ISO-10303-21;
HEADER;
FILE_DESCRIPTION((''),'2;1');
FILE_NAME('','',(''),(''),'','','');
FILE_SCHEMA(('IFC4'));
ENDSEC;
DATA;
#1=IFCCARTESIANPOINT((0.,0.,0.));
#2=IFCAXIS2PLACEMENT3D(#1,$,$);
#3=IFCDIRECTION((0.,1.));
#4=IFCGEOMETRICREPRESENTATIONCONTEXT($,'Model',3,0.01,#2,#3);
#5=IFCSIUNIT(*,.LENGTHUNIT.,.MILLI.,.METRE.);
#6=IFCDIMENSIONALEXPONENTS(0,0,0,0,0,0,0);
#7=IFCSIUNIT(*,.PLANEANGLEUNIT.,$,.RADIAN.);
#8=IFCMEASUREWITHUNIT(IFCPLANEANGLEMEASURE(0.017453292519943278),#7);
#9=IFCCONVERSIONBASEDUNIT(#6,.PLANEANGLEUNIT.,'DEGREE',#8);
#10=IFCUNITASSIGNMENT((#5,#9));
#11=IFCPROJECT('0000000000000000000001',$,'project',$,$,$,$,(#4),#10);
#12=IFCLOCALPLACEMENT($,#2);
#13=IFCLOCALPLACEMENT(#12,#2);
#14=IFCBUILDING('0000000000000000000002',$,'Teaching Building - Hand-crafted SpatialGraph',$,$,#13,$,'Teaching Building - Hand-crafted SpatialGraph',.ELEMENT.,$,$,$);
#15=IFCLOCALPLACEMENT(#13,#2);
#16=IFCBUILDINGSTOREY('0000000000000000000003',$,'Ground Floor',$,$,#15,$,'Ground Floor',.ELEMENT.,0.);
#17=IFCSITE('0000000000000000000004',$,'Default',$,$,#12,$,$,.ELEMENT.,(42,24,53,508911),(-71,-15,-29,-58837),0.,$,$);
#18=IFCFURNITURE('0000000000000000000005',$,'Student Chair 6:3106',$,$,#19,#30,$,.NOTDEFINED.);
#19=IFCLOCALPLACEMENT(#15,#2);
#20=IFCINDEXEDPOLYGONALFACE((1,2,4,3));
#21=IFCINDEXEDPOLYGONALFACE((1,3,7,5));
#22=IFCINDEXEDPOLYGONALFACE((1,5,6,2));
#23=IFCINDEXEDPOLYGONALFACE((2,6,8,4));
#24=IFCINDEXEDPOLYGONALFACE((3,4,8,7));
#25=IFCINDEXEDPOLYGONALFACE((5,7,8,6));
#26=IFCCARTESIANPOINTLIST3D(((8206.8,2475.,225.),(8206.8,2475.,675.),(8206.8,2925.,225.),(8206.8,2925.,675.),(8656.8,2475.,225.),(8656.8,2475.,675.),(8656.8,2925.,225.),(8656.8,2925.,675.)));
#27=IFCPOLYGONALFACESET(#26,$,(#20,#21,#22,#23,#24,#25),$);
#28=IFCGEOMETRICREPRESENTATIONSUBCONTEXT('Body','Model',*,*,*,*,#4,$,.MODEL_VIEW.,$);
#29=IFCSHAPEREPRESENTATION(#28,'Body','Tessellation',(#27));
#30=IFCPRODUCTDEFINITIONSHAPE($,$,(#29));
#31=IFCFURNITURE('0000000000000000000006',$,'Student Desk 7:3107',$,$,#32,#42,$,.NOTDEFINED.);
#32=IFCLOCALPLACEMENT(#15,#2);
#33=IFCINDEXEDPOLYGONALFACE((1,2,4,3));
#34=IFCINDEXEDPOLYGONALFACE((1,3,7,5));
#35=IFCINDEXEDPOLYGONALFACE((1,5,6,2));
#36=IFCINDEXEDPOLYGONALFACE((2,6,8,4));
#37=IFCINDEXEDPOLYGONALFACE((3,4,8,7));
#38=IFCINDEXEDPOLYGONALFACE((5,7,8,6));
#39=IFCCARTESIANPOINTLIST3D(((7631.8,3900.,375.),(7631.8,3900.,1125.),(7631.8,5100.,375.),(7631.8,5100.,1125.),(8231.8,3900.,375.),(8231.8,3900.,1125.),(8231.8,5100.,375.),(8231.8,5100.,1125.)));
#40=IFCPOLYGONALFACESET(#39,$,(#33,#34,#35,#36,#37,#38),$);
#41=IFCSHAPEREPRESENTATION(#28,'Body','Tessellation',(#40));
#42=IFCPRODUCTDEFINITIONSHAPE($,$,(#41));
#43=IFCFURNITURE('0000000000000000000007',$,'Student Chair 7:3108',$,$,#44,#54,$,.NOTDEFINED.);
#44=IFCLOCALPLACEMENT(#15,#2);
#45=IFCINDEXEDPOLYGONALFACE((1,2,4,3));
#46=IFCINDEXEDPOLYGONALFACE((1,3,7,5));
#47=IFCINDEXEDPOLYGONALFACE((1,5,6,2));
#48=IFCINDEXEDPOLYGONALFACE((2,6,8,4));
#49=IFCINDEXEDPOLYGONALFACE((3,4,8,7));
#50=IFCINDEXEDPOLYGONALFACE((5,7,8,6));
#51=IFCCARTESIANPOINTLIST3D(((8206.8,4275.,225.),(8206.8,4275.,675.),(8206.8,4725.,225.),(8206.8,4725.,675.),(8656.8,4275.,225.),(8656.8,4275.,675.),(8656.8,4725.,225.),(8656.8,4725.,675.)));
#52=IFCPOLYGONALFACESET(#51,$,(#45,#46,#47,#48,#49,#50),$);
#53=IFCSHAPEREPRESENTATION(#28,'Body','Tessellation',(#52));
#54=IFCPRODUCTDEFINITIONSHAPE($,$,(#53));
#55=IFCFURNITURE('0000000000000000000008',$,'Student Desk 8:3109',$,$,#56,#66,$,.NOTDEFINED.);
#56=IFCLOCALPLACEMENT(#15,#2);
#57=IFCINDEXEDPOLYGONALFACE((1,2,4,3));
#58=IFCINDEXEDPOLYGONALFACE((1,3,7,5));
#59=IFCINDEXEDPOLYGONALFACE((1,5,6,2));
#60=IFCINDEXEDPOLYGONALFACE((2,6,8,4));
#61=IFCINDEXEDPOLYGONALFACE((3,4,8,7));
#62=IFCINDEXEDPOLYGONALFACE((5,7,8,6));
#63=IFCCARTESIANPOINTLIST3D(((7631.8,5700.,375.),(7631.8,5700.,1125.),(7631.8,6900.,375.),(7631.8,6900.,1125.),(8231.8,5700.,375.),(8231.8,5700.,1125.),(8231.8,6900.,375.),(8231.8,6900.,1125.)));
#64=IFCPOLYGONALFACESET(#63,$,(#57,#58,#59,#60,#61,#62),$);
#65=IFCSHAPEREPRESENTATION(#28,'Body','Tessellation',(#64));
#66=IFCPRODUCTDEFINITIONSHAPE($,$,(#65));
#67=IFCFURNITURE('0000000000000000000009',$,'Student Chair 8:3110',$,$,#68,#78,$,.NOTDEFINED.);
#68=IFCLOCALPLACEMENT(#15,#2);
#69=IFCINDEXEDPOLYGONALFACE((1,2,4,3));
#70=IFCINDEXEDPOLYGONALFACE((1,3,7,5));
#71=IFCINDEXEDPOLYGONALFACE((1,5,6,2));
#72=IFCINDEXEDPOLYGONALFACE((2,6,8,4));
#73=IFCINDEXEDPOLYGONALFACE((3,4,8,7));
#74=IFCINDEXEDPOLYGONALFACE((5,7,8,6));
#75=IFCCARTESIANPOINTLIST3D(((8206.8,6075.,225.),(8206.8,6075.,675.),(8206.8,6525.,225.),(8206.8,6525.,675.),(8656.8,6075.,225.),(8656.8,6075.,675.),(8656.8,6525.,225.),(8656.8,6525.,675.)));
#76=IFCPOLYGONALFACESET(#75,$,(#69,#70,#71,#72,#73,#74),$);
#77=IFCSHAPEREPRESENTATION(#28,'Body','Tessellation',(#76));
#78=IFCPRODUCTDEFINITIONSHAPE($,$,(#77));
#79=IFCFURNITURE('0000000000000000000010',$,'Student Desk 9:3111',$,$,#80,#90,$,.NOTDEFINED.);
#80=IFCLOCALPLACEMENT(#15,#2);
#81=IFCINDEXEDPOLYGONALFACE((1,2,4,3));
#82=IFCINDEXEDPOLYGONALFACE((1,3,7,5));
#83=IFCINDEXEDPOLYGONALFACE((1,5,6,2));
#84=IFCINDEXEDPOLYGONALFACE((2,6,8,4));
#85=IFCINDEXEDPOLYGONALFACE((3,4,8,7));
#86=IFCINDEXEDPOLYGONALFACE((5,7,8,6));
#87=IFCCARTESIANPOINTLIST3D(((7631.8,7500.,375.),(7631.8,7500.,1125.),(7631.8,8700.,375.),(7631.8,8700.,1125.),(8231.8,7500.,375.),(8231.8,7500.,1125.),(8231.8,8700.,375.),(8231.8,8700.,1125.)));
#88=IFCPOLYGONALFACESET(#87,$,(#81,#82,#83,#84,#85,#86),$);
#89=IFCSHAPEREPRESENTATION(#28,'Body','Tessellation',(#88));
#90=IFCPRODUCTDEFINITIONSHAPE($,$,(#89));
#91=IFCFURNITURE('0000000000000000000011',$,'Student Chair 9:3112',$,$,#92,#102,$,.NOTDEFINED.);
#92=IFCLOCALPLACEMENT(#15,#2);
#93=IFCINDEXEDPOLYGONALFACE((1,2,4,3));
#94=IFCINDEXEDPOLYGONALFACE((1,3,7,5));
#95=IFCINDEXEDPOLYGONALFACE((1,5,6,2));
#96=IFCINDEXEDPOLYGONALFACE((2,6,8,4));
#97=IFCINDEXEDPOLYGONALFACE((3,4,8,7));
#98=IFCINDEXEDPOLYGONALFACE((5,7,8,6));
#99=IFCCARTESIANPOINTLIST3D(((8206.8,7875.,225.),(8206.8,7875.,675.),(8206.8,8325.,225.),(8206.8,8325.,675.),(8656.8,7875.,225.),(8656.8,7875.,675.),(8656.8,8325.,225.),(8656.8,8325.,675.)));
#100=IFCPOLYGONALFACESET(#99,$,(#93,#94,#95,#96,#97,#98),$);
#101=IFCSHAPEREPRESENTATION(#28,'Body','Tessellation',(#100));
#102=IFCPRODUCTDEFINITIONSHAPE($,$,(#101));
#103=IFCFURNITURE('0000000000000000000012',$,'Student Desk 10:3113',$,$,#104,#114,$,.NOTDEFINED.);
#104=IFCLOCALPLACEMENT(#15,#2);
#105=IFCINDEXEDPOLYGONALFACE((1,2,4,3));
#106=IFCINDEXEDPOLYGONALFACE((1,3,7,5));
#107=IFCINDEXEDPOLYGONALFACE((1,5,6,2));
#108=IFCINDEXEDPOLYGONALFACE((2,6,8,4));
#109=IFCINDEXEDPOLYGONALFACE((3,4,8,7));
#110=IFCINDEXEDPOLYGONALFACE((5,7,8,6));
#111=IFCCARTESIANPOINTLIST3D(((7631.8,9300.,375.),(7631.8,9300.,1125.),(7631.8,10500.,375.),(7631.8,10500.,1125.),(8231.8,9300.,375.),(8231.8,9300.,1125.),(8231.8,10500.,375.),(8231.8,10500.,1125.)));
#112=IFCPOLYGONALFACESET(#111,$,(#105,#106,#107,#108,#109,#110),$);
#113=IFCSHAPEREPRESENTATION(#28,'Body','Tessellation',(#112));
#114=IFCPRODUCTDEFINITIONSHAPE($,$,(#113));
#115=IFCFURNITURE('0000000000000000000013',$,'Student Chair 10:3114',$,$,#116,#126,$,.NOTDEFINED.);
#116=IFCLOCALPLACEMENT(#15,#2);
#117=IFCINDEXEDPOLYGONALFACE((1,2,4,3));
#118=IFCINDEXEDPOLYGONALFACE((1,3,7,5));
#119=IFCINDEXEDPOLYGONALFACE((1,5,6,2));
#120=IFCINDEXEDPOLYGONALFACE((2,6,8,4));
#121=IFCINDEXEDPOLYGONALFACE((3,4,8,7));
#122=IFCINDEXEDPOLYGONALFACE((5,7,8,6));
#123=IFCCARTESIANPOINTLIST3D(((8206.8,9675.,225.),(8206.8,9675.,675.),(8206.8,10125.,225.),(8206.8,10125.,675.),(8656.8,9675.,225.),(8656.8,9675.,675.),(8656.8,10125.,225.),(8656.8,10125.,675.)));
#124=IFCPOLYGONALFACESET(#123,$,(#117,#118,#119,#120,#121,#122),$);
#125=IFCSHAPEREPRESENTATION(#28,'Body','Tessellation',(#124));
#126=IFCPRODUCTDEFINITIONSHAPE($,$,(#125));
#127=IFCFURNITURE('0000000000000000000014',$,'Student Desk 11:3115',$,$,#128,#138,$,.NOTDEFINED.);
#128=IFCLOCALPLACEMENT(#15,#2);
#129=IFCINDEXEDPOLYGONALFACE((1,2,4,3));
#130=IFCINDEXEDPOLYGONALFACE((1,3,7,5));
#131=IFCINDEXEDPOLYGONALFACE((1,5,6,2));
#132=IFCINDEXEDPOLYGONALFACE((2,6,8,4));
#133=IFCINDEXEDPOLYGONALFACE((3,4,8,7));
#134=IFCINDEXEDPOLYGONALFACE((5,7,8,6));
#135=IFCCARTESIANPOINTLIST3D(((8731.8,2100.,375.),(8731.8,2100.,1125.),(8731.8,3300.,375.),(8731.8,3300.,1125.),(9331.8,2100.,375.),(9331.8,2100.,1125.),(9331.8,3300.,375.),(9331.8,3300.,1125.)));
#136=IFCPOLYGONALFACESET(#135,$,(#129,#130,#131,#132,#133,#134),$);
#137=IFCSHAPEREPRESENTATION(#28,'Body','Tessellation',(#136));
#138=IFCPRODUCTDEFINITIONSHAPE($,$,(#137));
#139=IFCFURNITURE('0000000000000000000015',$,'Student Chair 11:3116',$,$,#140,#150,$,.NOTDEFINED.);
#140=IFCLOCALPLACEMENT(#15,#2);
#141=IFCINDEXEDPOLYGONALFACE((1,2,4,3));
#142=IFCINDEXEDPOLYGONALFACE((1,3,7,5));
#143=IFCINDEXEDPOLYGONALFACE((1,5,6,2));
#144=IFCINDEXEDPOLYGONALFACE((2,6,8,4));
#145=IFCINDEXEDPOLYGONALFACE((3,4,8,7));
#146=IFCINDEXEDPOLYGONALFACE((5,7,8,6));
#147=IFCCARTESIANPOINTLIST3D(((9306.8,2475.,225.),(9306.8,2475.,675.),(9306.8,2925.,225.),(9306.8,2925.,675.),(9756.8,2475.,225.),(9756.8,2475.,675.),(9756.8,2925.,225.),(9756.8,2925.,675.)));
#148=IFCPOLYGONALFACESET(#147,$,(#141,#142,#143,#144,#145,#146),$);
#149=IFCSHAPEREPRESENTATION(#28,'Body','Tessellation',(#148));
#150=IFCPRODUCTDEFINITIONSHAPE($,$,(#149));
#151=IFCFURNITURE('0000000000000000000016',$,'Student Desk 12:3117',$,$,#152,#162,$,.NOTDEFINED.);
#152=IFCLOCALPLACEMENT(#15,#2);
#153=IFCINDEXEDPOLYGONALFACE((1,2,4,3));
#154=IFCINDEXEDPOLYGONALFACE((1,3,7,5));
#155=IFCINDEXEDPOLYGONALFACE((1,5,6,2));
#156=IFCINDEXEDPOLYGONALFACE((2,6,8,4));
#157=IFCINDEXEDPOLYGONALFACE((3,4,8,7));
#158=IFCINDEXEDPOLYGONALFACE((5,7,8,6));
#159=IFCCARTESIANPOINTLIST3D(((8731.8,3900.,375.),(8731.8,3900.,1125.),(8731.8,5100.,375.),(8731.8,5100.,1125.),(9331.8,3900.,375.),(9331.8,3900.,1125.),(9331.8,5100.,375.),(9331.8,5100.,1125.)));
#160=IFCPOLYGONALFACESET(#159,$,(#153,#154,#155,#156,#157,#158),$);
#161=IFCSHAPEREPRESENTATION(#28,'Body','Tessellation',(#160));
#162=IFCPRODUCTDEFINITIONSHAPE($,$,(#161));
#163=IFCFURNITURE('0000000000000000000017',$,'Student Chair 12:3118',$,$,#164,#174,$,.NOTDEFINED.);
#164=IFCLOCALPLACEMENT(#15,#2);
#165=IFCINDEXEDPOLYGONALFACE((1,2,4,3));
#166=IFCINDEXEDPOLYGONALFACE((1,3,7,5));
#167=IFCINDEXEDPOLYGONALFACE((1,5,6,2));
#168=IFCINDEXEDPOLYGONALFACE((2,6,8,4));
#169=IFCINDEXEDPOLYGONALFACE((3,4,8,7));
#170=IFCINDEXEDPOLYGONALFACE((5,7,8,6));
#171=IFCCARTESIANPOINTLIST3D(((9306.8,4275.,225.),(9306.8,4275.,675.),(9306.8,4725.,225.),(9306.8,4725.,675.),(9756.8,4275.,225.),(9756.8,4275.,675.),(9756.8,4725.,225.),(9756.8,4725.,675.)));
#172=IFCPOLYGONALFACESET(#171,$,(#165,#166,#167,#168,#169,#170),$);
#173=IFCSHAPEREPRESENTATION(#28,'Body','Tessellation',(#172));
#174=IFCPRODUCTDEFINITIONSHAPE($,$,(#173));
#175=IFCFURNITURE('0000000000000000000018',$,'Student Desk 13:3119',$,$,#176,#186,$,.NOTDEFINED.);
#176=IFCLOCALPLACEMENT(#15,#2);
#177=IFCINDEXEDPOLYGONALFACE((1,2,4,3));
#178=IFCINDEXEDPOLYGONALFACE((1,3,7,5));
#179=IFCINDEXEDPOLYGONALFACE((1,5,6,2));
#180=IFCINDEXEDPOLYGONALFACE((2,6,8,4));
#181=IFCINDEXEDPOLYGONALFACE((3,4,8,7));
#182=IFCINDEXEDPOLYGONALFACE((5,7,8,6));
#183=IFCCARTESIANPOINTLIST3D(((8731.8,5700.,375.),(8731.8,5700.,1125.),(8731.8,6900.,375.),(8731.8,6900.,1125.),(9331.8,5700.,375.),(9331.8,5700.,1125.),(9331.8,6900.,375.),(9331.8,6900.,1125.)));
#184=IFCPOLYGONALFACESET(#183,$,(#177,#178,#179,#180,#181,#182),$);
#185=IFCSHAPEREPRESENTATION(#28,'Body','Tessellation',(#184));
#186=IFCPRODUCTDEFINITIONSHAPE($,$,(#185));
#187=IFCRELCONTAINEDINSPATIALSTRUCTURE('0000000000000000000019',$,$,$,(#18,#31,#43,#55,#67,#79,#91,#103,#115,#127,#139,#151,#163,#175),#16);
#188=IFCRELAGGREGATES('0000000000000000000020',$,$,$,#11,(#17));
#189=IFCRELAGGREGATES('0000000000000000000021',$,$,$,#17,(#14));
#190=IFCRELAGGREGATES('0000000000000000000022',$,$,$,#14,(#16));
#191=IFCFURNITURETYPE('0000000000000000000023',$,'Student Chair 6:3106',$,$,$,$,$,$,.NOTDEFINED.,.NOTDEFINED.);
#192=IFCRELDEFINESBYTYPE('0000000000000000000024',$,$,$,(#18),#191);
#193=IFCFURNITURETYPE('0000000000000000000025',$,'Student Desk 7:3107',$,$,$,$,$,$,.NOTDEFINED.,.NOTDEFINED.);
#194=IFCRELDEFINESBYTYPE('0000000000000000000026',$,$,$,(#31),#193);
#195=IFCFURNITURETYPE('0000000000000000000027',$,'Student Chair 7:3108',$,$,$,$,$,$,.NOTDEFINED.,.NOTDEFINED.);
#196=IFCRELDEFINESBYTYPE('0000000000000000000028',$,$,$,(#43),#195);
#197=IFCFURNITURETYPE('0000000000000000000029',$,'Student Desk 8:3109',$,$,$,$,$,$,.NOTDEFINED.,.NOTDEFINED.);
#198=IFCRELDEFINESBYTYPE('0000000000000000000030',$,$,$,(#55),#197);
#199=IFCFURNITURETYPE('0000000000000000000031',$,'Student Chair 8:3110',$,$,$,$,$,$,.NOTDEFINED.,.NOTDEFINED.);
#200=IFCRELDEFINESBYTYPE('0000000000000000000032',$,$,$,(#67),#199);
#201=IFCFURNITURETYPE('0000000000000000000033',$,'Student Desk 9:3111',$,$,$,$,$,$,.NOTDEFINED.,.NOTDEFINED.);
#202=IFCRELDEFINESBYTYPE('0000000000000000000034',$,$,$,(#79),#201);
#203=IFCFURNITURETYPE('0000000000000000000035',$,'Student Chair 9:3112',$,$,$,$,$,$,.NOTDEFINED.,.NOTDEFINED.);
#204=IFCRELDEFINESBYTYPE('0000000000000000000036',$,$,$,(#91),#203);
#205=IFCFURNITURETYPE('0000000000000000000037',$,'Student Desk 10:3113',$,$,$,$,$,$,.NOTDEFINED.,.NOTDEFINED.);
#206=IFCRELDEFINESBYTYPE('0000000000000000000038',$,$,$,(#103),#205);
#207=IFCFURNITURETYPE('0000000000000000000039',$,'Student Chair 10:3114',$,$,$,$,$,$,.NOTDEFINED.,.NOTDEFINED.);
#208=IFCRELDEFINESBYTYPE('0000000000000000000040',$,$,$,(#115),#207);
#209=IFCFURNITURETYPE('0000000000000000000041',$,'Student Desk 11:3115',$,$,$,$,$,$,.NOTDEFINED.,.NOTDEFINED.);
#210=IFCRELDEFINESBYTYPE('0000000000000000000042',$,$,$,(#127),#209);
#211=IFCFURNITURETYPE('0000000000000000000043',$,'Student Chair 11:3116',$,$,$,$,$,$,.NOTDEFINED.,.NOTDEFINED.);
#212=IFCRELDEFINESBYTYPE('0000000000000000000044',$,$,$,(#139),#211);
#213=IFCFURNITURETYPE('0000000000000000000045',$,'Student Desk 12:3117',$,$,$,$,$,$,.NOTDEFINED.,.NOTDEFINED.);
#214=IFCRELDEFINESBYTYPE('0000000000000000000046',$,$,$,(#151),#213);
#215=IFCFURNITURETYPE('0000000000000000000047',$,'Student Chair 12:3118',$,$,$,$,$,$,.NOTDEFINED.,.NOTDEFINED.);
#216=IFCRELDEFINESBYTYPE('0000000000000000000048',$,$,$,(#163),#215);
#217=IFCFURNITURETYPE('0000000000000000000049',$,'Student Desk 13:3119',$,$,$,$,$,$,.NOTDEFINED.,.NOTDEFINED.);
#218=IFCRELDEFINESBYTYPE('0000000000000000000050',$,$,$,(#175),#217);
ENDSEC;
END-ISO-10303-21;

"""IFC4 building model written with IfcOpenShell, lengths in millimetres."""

from ifc_helpers import new_model, entity, si_unit, converted_unit, direction, frame, frame_2d, origin, origin_2d_with_axis, place, context, subcontext, project, spatial, rectangle, extrude, type_object, element, save


model = new_model("IFC4")

# Units and contexts
model_context = context("Model", 3, precision=0.01, world=origin(), true_north=direction((0.0, 1.0)))
body_context = subcontext(model_context, "Body", "Model", "MODEL_VIEW")
ifc_project = project(units=[si_unit("LENGTHUNIT", "METRE", prefix="MILLI"), converted_unit("PLANEANGLEUNIT", "DEGREE", entity("IfcPlaneAngleMeasure", 0.017453292519943278), si_unit("PLANEANGLEUNIT", "RADIAN"), dimensions=[0, 0, 0, 0, 0, 0, 0])], contexts=[model_context])

# Site, building, storey
site_placement = place(None, origin())
site = spatial("IfcSite", under=ifc_project, at=site_placement, Name="Default", CompositionType="ELEMENT", RefLatitude=(42, 24, 53, 508911), RefLongitude=(-71, -15, -29, -58837), RefElevation=0.0)
building_placement = place(site_placement, origin())
building = spatial("IfcBuilding", under=site, at=building_placement, Name="Teaching Building - Hand-crafted SpatialGraph", LongName="Teaching Building - Hand-crafted SpatialGraph", CompositionType="ELEMENT")
storey_placement = place(building_placement, origin())
storey = spatial("IfcBuildingStorey", under=building, at=storey_placement, Name="Ground Floor", LongName="Ground Floor", CompositionType="ELEMENT", Elevation=0.0)

# Furniture
furniture_type_1 = type_object("IfcFurnitureType", Name="Student Chair 6:3106", PredefinedType="NOTDEFINED")
furniture_1_placement = place(storey_placement, origin())
element("IfcFurniture", 1, at=furniture_1_placement, inside=storey, type_object=furniture_type_1, Name="Student Chair 6:3106", PredefinedType="NOTDEFINED", context=body_context, shape_type="SweptSolid", body=[
    extrude(rectangle(XDim=450.0, YDim=450.0, at=origin_2d_with_axis()), frame((8431.8, 2700.0, 225.0)), (0.0, 0.0, 1.0), 450.0),
])
furniture_type_2 = type_object("IfcFurnitureType", Name="Student Desk 7:3107", PredefinedType="NOTDEFINED")
furniture_2_placement = place(storey_placement, origin())
element("IfcFurniture", 2, at=furniture_2_placement, inside=storey, type_object=furniture_type_2, Name="Student Desk 7:3107", PredefinedType="NOTDEFINED", context=body_context, shape_type="SweptSolid", body=[
    extrude(rectangle(XDim=1200.0, YDim=600.0, at=frame_2d((0.0, 0.0), x_axis=(1.0, 0.0))), frame((7931.8, 4500.0, 375.0), z_axis=(0.0, 0.0, 1.0), x_axis=(0.0, 1.0, 0.0)), (0.0, 0.0, 1.0), 750.0),
])
furniture_type_3 = type_object("IfcFurnitureType", Name="Student Chair 7:3108", PredefinedType="NOTDEFINED")
furniture_3_placement = place(storey_placement, origin())
element("IfcFurniture", 3, at=furniture_3_placement, inside=storey, type_object=furniture_type_3, Name="Student Chair 7:3108", PredefinedType="NOTDEFINED", context=body_context, shape_type="SweptSolid", body=[
    extrude(rectangle(XDim=450.0, YDim=450.0, at=origin_2d_with_axis()), frame((8431.8, 4500.0, 225.0)), (0.0, 0.0, 1.0), 450.0),
])
furniture_type_4 = type_object("IfcFurnitureType", Name="Student Desk 8:3109", PredefinedType="NOTDEFINED")
furniture_4_placement = place(storey_placement, origin())
element("IfcFurniture", 4, at=furniture_4_placement, inside=storey, type_object=furniture_type_4, Name="Student Desk 8:3109", PredefinedType="NOTDEFINED", context=body_context, shape_type="SweptSolid", body=[
    extrude(rectangle(XDim=1200.0, YDim=600.0, at=origin_2d_with_axis()), frame((7931.8, 6300.0, 375.0), z_axis=(0.0, 0.0, 1.0), x_axis=(0.0, 1.0, 0.0)), (0.0, 0.0, 1.0), 750.0),
])
furniture_type_5 = type_object("IfcFurnitureType", Name="Student Chair 8:3110", PredefinedType="NOTDEFINED")
furniture_5_placement = place(storey_placement, origin())
element("IfcFurniture", 5, at=furniture_5_placement, inside=storey, type_object=furniture_type_5, Name="Student Chair 8:3110", PredefinedType="NOTDEFINED", context=body_context, shape_type="SweptSolid", body=[
    extrude(rectangle(XDim=450.0, YDim=450.0, at=origin_2d_with_axis()), frame((8431.8, 6300.0, 225.0)), (0.0, 0.0, 1.0), 450.0),
])
furniture_type_6 = type_object("IfcFurnitureType", Name="Student Desk 9:3111", PredefinedType="NOTDEFINED")
furniture_6_placement = place(storey_placement, origin())
element("IfcFurniture", 6, at=furniture_6_placement, inside=storey, type_object=furniture_type_6, Name="Student Desk 9:3111", PredefinedType="NOTDEFINED", context=body_context, shape_type="SweptSolid", body=[
    extrude(rectangle(XDim=1200.0, YDim=600.0, at=origin_2d_with_axis()), frame((7931.8, 8100.0, 375.0), z_axis=(0.0, 0.0, 1.0), x_axis=(0.0, 1.0, 0.0)), (0.0, 0.0, 1.0), 750.0),
])
furniture_type_7 = type_object("IfcFurnitureType", Name="Student Chair 9:3112", PredefinedType="NOTDEFINED")
furniture_7_placement = place(storey_placement, origin())
element("IfcFurniture", 7, at=furniture_7_placement, inside=storey, type_object=furniture_type_7, Name="Student Chair 9:3112", PredefinedType="NOTDEFINED", context=body_context, shape_type="SweptSolid", body=[
    extrude(rectangle(XDim=450.0, YDim=450.0, at=origin_2d_with_axis()), frame((8431.8, 8100.0, 225.0)), (0.0, 0.0, 1.0), 450.0),
])
furniture_type_8 = type_object("IfcFurnitureType", Name="Student Desk 10:3113", PredefinedType="NOTDEFINED")
furniture_8_placement = place(storey_placement, origin())
element("IfcFurniture", 8, at=furniture_8_placement, inside=storey, type_object=furniture_type_8, Name="Student Desk 10:3113", PredefinedType="NOTDEFINED", context=body_context, shape_type="SweptSolid", body=[
    extrude(rectangle(XDim=1200.0, YDim=600.0, at=origin_2d_with_axis()), frame((7931.8, 9900.0, 375.0), z_axis=(0.0, 0.0, 1.0), x_axis=(0.0, 1.0, 0.0)), (0.0, 0.0, 1.0), 750.0),
])
furniture_type_9 = type_object("IfcFurnitureType", Name="Student Chair 10:3114", PredefinedType="NOTDEFINED")
furniture_9_placement = place(storey_placement, origin())
element("IfcFurniture", 9, at=furniture_9_placement, inside=storey, type_object=furniture_type_9, Name="Student Chair 10:3114", PredefinedType="NOTDEFINED", context=body_context, shape_type="SweptSolid", body=[
    extrude(rectangle(XDim=450.0, YDim=450.0, at=frame_2d((0.0, 0.0), x_axis=(1.0, 0.0))), frame((8431.8, 9900.0, 225.0)), (0.0, 0.0, 1.0), 450.0),
])
furniture_type_10 = type_object("IfcFurnitureType", Name="Student Desk 11:3115", PredefinedType="NOTDEFINED")
furniture_10_placement = place(storey_placement, origin())
element("IfcFurniture", 10, at=furniture_10_placement, inside=storey, type_object=furniture_type_10, Name="Student Desk 11:3115", PredefinedType="NOTDEFINED", context=body_context, shape_type="SweptSolid", body=[
    extrude(rectangle(XDim=1200.0, YDim=600.0, at=origin_2d_with_axis()), frame((9031.8, 2700.0, 375.0), z_axis=(0.0, 0.0, 1.0), x_axis=(0.0, 1.0, 0.0)), (0.0, 0.0, 1.0), 750.0),
])
furniture_type_11 = type_object("IfcFurnitureType", Name="Student Chair 11:3116", PredefinedType="NOTDEFINED")
furniture_11_placement = place(storey_placement, origin())
element("IfcFurniture", 11, at=furniture_11_placement, inside=storey, type_object=furniture_type_11, Name="Student Chair 11:3116", PredefinedType="NOTDEFINED", context=body_context, shape_type="SweptSolid", body=[
    extrude(rectangle(XDim=450.0, YDim=450.0, at=origin_2d_with_axis()), frame((9531.8, 2700.0, 225.0)), (0.0, 0.0, 1.0), 450.0),
])
furniture_type_12 = type_object("IfcFurnitureType", Name="Student Desk 12:3117", PredefinedType="NOTDEFINED")
furniture_12_placement = place(storey_placement, origin())
element("IfcFurniture", 12, at=furniture_12_placement, inside=storey, type_object=furniture_type_12, Name="Student Desk 12:3117", PredefinedType="NOTDEFINED", context=body_context, shape_type="SweptSolid", body=[
    extrude(rectangle(XDim=1200.0, YDim=600.0, at=frame_2d((0.0, 0.0), x_axis=(1.0, 0.0))), frame((9031.8, 4500.0, 375.0), z_axis=(0.0, 0.0, 1.0), x_axis=(0.0, 1.0, 0.0)), (0.0, 0.0, 1.0), 750.0),
])
furniture_type_13 = type_object("IfcFurnitureType", Name="Student Chair 12:3118", PredefinedType="NOTDEFINED")
furniture_13_placement = place(storey_placement, origin())
element("IfcFurniture", 13, at=furniture_13_placement, inside=storey, type_object=furniture_type_13, Name="Student Chair 12:3118", PredefinedType="NOTDEFINED", context=body_context, shape_type="SweptSolid", body=[
    extrude(rectangle(XDim=450.0, YDim=450.0, at=origin_2d_with_axis()), frame((9531.8, 4500.0, 225.0)), (0.0, 0.0, 1.0), 450.0),
])
furniture_type_14 = type_object("IfcFurnitureType", Name="Student Desk 13:3119", PredefinedType="NOTDEFINED")
furniture_14_placement = place(storey_placement, origin())
element("IfcFurniture", 14, at=furniture_14_placement, inside=storey, type_object=furniture_type_14, Name="Student Desk 13:3119", PredefinedType="NOTDEFINED", context=body_context, shape_type="SweptSolid", body=[
    extrude(rectangle(XDim=1200.0, YDim=600.0, at=origin_2d_with_axis()), frame((9031.8, 6300.0, 375.0), z_axis=(0.0, 0.0, 1.0), x_axis=(0.0, 1.0, 0.0)), (0.0, 0.0, 1.0), 750.0),
])

save(model, "model.ifc")
